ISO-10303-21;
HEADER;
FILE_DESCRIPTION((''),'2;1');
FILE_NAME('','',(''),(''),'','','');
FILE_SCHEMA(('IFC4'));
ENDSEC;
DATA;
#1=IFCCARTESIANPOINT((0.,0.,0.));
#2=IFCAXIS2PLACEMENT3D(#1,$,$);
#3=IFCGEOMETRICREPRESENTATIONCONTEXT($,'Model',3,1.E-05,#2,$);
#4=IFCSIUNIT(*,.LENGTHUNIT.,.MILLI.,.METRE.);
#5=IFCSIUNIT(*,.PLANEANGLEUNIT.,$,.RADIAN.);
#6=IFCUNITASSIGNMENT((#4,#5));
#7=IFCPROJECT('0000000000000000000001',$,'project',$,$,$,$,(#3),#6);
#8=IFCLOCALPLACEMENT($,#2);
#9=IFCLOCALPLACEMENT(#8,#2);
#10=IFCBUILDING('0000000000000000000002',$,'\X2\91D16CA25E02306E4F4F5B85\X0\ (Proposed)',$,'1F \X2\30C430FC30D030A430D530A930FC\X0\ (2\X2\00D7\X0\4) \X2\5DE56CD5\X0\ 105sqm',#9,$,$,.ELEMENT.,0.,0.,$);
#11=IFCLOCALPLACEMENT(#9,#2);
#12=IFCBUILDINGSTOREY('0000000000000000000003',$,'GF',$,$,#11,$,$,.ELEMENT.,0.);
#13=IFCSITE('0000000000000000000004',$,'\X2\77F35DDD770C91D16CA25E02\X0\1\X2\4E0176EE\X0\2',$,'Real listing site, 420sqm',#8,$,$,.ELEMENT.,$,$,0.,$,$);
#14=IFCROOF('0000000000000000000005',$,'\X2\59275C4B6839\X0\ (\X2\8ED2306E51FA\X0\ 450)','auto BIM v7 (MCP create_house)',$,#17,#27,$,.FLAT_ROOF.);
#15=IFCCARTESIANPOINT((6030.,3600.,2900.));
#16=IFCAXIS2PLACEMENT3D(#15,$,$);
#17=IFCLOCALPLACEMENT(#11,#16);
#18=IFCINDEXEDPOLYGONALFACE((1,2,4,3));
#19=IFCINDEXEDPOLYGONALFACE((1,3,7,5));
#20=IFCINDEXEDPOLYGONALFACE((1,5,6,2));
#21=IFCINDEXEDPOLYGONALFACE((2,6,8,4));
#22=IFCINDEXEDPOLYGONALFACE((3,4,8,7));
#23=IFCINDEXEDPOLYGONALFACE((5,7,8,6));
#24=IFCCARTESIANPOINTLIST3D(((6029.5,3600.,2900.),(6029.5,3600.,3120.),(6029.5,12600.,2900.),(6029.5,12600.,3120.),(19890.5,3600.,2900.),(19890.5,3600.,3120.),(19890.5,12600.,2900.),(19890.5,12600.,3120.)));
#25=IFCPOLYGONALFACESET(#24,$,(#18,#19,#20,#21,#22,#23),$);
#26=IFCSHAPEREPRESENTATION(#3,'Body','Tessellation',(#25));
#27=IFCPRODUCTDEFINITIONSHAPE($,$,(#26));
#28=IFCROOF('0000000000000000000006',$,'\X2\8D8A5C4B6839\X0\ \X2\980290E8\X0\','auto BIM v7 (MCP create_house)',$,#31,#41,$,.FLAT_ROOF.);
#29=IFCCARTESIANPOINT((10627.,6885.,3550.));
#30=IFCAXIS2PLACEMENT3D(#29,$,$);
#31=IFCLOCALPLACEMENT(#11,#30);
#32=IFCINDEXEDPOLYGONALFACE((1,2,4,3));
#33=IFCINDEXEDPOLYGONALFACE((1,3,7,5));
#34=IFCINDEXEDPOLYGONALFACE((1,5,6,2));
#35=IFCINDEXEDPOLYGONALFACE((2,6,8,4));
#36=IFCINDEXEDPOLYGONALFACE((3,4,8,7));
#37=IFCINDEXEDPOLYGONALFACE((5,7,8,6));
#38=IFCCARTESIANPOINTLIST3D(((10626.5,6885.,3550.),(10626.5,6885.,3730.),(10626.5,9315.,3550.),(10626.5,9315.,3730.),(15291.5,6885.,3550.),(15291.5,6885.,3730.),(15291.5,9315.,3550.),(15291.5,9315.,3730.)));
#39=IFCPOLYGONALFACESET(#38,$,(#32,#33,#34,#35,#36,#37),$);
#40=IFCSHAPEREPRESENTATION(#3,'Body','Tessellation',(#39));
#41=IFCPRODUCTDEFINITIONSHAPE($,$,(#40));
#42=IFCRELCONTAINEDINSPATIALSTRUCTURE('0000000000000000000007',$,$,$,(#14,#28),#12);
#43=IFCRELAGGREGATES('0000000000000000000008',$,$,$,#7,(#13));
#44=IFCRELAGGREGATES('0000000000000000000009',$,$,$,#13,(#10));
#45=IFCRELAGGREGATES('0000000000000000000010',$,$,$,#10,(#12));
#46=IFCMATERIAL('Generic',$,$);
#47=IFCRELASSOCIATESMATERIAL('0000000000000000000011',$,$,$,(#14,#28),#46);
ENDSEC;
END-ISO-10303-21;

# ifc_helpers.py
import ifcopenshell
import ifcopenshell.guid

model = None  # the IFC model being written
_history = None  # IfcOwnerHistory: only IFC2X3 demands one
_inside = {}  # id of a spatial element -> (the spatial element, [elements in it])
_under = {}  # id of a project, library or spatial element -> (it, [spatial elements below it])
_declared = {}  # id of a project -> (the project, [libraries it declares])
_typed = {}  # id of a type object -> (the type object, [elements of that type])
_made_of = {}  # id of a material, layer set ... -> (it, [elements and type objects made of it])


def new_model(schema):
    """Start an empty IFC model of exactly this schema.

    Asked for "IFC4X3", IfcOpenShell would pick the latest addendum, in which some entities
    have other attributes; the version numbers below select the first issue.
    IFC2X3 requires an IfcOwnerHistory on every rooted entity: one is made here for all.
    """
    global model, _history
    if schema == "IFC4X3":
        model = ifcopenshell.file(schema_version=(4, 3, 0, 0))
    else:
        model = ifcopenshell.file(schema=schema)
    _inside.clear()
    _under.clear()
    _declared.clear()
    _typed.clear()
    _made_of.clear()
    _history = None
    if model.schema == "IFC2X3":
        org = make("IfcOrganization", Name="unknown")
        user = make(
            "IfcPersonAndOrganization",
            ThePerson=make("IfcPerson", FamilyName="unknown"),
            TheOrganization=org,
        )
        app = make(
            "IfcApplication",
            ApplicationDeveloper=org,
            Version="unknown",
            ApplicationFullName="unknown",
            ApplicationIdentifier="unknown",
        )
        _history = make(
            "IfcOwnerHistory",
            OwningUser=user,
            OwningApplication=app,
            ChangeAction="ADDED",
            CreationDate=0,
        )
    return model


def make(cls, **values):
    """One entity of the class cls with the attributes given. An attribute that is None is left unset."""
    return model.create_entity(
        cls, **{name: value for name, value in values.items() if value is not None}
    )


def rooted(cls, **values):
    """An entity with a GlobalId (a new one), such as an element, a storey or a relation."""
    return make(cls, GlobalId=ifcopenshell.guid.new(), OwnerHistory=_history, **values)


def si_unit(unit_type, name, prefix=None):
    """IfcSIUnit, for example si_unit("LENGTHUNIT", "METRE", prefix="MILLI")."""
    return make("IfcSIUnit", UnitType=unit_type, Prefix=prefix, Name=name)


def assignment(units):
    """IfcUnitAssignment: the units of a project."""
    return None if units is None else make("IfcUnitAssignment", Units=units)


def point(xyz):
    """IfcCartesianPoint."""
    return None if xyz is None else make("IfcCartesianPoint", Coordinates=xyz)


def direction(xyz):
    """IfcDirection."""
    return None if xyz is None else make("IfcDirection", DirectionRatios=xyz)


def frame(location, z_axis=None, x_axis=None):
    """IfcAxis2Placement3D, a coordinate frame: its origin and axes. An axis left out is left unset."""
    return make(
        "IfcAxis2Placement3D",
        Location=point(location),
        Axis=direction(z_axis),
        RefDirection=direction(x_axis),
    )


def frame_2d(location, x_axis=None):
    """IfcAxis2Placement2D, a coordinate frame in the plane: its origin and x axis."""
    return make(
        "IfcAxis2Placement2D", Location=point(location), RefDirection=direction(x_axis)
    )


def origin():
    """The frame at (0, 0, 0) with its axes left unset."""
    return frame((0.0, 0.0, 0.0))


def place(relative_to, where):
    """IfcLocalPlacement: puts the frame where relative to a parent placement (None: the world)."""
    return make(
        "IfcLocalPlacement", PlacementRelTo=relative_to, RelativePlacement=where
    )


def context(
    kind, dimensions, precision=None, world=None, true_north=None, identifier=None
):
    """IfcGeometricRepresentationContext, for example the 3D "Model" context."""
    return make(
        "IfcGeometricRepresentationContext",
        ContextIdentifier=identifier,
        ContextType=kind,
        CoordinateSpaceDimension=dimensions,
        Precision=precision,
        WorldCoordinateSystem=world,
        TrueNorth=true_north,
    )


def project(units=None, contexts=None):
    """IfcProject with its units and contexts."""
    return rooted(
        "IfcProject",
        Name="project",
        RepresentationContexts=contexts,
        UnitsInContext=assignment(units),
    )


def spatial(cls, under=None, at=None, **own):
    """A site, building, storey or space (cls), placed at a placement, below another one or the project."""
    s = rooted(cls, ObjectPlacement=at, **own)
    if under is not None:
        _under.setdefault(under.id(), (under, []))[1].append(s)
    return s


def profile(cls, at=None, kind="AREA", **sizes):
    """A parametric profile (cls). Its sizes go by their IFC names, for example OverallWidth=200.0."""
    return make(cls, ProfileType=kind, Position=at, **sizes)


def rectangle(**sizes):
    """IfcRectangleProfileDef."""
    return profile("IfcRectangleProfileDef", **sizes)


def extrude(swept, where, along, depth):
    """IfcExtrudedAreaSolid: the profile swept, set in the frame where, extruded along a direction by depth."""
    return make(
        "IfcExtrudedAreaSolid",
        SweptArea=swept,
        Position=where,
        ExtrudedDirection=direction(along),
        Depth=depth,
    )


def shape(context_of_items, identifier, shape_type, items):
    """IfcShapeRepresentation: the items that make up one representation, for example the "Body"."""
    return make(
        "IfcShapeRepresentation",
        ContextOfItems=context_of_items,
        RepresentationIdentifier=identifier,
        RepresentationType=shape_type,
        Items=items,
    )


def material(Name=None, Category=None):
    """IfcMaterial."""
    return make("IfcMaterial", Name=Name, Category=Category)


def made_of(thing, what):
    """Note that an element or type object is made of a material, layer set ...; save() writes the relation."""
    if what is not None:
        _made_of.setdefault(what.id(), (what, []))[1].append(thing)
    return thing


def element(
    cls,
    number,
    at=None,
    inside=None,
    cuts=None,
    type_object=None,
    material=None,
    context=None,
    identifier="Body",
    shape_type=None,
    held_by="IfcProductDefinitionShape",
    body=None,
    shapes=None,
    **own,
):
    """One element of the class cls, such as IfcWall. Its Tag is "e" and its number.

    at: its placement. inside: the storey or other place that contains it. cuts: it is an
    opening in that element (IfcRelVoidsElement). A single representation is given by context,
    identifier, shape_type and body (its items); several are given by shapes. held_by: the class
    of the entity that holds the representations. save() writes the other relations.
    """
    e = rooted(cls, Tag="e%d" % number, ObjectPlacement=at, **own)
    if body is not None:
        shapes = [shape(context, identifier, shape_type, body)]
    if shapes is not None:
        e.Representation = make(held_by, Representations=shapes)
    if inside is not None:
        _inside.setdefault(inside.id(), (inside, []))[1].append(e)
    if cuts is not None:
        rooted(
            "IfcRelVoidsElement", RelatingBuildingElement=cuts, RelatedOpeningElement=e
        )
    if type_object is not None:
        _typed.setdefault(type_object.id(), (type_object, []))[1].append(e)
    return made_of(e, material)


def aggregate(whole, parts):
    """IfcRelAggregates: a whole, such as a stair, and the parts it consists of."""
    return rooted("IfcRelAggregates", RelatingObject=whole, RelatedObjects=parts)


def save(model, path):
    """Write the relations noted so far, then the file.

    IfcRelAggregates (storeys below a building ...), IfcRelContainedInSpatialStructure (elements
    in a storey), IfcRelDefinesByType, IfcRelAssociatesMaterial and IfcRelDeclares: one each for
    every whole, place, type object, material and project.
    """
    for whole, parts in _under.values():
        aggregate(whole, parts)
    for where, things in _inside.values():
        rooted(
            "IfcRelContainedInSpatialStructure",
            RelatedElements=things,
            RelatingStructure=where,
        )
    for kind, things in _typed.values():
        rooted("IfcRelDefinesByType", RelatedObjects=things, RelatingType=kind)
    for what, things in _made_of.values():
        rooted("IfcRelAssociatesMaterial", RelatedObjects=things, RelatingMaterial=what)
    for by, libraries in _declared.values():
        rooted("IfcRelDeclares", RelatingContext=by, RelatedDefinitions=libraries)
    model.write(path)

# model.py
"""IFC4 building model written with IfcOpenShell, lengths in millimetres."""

from ifc_helpers import new_model, si_unit, frame, frame_2d, origin, place, context, project, spatial, rectangle, extrude, material, element, save


model = new_model("IFC4")

# Units and contexts
model_context = context("Model", 3, precision=1e-05, world=origin())
ifc_project = project(units=[si_unit("LENGTHUNIT", "METRE", prefix="MILLI"), si_unit("PLANEANGLEUNIT", "RADIAN")], contexts=[model_context])

# Site, building, storey
site_placement = place(None, origin())
site = spatial("IfcSite", under=ifc_project, at=site_placement, Name="石川県金沢市1丁目2", ObjectType="Real listing site, 420sqm", CompositionType="ELEMENT", RefElevation=0.0)
building_placement = place(site_placement, origin())
building = spatial("IfcBuilding", under=site, at=building_placement, Name="金沢市の住宅 (Proposed)", ObjectType="1F ツーバイフォー (2×4) 工法 105sqm", CompositionType="ELEMENT", ElevationOfRefHeight=0.0, ElevationOfTerrain=0.0)
storey_placement = place(building_placement, origin())
storey = spatial("IfcBuildingStorey", under=building, at=storey_placement, Name="GF", CompositionType="ELEMENT", Elevation=0.0)

# Shared definitions
ifc_material = material(Name="Generic")

# Roofs
roof_1_placement = place(storey_placement, frame((6030.0, 3600.0, 2900.0)))
element("IfcRoof", 1, at=roof_1_placement, inside=storey, material=ifc_material, Name="大屋根 (軒の出 450)", Description="auto BIM v7 (MCP create_house)", PredefinedType="FLAT_ROOF", context=model_context, shape_type="SweptSolid", body=[
    extrude(rectangle(XDim=13861.0, YDim=9000.0, at=frame_2d((6930.0, 4500.0))), frame((6030.0, 3600.0, 2900.0)), (0.0, 0.0, 1.0), 220.0),
])
roof_2_placement = place(storey_placement, frame((10627.0, 6885.0, 3550.0)))
element("IfcRoof", 2, at=roof_2_placement, inside=storey, material=ifc_material, Name="越屋根 頂部", Description="auto BIM v7 (MCP create_house)", PredefinedType="FLAT_ROOF", context=model_context, shape_type="SweptSolid", body=[
    extrude(rectangle(XDim=4665.0, YDim=2430.0, at=frame_2d((2332.0, 1215.0))), frame((10627.0, 6885.0, 3550.0)), (0.0, 0.0, 1.0), 180.0),
])

save(model, "model.ifc")
